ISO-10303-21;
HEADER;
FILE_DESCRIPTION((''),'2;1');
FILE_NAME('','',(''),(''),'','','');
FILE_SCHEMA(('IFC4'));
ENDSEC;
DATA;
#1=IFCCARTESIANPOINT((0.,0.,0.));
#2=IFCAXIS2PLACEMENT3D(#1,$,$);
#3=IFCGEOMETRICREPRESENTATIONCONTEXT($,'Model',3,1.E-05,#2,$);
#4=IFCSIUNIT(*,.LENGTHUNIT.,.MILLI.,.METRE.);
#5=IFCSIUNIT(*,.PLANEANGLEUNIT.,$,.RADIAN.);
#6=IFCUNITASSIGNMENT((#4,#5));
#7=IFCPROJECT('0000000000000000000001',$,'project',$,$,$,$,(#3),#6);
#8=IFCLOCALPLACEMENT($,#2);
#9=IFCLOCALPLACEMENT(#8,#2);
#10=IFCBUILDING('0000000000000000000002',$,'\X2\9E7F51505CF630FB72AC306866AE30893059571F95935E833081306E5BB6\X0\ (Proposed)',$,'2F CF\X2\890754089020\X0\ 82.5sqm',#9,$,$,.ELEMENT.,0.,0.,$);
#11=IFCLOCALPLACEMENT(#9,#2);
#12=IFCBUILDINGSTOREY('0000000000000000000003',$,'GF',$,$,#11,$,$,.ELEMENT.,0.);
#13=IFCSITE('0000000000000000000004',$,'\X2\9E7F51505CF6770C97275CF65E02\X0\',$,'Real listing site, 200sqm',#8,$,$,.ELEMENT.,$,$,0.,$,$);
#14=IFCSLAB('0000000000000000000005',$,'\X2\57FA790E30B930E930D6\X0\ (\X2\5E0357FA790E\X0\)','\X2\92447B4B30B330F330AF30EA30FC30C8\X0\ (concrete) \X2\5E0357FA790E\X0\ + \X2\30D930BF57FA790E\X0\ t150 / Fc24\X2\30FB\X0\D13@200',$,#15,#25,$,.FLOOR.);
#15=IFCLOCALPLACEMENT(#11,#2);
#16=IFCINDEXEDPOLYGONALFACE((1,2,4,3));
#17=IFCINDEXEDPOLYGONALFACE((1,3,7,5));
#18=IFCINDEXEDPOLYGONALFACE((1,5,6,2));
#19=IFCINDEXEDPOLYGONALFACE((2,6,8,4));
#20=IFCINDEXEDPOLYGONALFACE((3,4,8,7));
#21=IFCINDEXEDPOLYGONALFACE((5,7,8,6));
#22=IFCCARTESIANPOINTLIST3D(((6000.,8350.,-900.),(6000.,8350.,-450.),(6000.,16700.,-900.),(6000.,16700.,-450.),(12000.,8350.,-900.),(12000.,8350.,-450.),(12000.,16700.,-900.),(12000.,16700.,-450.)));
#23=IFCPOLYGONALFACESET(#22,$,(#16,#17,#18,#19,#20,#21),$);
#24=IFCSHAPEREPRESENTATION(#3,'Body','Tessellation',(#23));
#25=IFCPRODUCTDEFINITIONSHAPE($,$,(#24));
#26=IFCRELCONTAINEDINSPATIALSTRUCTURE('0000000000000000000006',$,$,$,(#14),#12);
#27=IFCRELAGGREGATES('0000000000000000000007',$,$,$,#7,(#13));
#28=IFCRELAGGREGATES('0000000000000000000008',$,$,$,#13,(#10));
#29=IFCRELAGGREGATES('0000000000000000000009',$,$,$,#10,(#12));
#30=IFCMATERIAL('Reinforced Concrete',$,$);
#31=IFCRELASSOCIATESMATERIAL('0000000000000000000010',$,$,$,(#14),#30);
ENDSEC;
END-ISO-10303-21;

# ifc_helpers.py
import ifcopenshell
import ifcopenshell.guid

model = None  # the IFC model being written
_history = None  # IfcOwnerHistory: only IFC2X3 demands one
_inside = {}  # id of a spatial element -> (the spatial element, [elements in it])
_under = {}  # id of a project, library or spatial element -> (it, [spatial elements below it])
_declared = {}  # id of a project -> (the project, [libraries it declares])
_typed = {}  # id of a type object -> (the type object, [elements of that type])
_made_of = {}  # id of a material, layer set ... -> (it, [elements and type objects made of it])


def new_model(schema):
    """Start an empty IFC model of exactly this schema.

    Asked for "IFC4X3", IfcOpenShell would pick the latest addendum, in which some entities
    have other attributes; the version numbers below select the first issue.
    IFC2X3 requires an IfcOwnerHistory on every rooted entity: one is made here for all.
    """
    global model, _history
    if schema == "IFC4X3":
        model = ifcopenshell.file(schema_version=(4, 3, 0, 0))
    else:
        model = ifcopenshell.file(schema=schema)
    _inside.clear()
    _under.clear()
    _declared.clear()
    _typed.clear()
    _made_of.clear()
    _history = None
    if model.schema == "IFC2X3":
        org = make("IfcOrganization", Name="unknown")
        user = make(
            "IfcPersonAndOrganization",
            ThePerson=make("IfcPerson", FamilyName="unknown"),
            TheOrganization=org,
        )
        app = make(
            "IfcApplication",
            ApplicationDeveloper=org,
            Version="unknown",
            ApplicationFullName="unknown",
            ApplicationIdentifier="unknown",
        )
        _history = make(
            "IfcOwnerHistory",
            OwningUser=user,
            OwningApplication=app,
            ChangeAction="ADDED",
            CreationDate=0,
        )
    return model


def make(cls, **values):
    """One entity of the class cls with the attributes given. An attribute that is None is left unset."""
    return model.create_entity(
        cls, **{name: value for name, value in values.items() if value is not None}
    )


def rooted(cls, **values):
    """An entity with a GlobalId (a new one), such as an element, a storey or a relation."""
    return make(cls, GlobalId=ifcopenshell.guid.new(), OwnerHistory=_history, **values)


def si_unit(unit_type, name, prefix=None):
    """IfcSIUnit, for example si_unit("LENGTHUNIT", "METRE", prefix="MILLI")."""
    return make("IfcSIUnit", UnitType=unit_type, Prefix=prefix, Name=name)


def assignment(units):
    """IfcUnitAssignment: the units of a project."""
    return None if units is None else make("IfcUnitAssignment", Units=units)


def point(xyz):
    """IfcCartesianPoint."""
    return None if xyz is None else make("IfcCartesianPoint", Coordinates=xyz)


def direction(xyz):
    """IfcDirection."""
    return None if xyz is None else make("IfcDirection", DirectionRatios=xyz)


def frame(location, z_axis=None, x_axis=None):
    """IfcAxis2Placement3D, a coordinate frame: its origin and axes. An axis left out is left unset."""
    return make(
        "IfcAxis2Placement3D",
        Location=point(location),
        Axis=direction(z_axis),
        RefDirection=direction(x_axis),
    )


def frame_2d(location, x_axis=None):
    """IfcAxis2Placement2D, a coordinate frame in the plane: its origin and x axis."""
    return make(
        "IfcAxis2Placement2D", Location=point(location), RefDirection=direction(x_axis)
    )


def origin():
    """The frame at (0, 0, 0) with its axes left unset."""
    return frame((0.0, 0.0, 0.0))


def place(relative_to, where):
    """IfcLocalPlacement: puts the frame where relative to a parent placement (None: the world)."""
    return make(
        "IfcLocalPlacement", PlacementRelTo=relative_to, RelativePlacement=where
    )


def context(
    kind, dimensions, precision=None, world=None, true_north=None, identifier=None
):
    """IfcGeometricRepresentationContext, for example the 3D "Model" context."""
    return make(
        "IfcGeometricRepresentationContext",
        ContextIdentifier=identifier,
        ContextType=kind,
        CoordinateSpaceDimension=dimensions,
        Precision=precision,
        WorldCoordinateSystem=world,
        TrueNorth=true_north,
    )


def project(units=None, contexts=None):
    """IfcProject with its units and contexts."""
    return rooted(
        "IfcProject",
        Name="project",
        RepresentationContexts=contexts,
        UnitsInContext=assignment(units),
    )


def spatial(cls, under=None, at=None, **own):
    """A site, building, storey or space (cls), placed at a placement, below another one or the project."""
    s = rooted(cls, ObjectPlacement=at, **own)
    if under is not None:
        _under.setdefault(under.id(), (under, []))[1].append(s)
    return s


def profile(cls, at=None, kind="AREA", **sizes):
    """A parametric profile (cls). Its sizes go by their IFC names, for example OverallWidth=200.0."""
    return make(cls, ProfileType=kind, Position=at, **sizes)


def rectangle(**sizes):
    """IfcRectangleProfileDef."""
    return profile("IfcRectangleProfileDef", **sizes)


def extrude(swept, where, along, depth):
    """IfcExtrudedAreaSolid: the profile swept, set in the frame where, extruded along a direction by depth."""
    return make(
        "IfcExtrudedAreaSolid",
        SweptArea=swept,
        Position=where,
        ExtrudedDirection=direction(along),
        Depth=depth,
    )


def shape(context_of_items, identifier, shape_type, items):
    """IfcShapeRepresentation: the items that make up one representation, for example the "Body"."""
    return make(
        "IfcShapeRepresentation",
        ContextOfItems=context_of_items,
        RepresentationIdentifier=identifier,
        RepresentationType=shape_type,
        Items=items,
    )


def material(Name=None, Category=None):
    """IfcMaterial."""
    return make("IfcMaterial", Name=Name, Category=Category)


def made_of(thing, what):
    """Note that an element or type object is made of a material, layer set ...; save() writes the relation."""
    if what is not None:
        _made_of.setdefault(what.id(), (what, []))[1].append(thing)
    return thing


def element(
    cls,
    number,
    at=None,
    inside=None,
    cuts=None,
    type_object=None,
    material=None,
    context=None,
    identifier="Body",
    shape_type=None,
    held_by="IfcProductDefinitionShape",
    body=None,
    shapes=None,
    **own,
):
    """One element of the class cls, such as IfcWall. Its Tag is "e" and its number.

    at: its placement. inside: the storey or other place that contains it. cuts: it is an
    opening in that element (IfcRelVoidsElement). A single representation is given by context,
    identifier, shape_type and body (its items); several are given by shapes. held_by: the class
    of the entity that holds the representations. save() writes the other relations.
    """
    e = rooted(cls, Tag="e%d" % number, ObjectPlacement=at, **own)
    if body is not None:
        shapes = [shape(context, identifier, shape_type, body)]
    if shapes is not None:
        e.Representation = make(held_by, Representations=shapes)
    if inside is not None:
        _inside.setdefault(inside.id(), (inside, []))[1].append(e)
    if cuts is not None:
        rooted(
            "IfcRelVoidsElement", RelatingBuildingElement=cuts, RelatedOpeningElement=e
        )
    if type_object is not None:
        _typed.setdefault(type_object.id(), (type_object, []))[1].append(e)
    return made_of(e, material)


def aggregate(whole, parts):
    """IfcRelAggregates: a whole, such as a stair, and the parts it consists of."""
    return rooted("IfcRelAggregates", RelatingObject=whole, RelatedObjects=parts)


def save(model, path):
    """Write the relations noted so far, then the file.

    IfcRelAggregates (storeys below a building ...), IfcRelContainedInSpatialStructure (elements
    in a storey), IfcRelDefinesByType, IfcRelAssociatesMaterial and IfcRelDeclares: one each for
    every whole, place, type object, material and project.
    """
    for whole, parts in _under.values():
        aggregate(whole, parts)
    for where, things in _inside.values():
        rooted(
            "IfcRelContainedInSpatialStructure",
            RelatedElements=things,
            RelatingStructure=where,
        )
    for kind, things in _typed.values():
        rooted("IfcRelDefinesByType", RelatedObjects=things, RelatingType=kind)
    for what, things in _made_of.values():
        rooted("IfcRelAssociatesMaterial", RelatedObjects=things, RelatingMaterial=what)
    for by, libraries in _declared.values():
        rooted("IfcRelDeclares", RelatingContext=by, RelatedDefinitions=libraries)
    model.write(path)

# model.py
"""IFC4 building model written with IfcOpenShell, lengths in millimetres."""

from ifc_helpers import new_model, si_unit, frame, frame_2d, origin, place, context, project, spatial, rectangle, extrude, material, element, save


model = new_model("IFC4")

# Units and contexts
model_context = context("Model", 3, precision=1e-05, world=origin())
ifc_project = project(units=[si_unit("LENGTHUNIT", "METRE", prefix="MILLI"), si_unit("PLANEANGLEUNIT", "RADIAN")], contexts=[model_context])

# Site, building, storey
site_placement = place(None, origin())
site = spatial("IfcSite", under=ifc_project, at=site_placement, Name="鹿児島県霧島市", ObjectType="Real listing site, 200sqm", CompositionType="ELEMENT", RefElevation=0.0)
building_placement = place(site_placement, origin())
building = spatial("IfcBuilding", under=site, at=building_placement, Name="鹿児島・犬と暮らす土間広めの家 (Proposed)", ObjectType="2F CF複合造 82.5sqm", CompositionType="ELEMENT", ElevationOfRefHeight=0.0, ElevationOfTerrain=0.0)
storey_placement = place(building_placement, origin())
storey = spatial("IfcBuildingStorey", under=building, at=storey_placement, Name="GF", CompositionType="ELEMENT", Elevation=0.0)

# Slab
ifc_material_1 = material(Name="Reinforced Concrete")
slab_1_placement = place(storey_placement, frame((3000.0, 4175.0, -450.0)))
element("IfcSlab", 1, at=slab_1_placement, inside=storey, material=ifc_material_1, Name="基礎スラブ (布基礎)", Description="鉄筋コンクリート (concrete) 布基礎 + ベタ基礎 t150 / Fc24・D13@200", PredefinedType="FLOOR", context=model_context, shape_type="SweptSolid", body=[
    extrude(rectangle(XDim=6000.0, YDim=8350.0, at=frame_2d((3000.0, 4175.0))), frame((3000.0, 4175.0, -450.0)), (0.0, 0.0, 1.0), 450.0),
])

save(model, "model.ifc")
